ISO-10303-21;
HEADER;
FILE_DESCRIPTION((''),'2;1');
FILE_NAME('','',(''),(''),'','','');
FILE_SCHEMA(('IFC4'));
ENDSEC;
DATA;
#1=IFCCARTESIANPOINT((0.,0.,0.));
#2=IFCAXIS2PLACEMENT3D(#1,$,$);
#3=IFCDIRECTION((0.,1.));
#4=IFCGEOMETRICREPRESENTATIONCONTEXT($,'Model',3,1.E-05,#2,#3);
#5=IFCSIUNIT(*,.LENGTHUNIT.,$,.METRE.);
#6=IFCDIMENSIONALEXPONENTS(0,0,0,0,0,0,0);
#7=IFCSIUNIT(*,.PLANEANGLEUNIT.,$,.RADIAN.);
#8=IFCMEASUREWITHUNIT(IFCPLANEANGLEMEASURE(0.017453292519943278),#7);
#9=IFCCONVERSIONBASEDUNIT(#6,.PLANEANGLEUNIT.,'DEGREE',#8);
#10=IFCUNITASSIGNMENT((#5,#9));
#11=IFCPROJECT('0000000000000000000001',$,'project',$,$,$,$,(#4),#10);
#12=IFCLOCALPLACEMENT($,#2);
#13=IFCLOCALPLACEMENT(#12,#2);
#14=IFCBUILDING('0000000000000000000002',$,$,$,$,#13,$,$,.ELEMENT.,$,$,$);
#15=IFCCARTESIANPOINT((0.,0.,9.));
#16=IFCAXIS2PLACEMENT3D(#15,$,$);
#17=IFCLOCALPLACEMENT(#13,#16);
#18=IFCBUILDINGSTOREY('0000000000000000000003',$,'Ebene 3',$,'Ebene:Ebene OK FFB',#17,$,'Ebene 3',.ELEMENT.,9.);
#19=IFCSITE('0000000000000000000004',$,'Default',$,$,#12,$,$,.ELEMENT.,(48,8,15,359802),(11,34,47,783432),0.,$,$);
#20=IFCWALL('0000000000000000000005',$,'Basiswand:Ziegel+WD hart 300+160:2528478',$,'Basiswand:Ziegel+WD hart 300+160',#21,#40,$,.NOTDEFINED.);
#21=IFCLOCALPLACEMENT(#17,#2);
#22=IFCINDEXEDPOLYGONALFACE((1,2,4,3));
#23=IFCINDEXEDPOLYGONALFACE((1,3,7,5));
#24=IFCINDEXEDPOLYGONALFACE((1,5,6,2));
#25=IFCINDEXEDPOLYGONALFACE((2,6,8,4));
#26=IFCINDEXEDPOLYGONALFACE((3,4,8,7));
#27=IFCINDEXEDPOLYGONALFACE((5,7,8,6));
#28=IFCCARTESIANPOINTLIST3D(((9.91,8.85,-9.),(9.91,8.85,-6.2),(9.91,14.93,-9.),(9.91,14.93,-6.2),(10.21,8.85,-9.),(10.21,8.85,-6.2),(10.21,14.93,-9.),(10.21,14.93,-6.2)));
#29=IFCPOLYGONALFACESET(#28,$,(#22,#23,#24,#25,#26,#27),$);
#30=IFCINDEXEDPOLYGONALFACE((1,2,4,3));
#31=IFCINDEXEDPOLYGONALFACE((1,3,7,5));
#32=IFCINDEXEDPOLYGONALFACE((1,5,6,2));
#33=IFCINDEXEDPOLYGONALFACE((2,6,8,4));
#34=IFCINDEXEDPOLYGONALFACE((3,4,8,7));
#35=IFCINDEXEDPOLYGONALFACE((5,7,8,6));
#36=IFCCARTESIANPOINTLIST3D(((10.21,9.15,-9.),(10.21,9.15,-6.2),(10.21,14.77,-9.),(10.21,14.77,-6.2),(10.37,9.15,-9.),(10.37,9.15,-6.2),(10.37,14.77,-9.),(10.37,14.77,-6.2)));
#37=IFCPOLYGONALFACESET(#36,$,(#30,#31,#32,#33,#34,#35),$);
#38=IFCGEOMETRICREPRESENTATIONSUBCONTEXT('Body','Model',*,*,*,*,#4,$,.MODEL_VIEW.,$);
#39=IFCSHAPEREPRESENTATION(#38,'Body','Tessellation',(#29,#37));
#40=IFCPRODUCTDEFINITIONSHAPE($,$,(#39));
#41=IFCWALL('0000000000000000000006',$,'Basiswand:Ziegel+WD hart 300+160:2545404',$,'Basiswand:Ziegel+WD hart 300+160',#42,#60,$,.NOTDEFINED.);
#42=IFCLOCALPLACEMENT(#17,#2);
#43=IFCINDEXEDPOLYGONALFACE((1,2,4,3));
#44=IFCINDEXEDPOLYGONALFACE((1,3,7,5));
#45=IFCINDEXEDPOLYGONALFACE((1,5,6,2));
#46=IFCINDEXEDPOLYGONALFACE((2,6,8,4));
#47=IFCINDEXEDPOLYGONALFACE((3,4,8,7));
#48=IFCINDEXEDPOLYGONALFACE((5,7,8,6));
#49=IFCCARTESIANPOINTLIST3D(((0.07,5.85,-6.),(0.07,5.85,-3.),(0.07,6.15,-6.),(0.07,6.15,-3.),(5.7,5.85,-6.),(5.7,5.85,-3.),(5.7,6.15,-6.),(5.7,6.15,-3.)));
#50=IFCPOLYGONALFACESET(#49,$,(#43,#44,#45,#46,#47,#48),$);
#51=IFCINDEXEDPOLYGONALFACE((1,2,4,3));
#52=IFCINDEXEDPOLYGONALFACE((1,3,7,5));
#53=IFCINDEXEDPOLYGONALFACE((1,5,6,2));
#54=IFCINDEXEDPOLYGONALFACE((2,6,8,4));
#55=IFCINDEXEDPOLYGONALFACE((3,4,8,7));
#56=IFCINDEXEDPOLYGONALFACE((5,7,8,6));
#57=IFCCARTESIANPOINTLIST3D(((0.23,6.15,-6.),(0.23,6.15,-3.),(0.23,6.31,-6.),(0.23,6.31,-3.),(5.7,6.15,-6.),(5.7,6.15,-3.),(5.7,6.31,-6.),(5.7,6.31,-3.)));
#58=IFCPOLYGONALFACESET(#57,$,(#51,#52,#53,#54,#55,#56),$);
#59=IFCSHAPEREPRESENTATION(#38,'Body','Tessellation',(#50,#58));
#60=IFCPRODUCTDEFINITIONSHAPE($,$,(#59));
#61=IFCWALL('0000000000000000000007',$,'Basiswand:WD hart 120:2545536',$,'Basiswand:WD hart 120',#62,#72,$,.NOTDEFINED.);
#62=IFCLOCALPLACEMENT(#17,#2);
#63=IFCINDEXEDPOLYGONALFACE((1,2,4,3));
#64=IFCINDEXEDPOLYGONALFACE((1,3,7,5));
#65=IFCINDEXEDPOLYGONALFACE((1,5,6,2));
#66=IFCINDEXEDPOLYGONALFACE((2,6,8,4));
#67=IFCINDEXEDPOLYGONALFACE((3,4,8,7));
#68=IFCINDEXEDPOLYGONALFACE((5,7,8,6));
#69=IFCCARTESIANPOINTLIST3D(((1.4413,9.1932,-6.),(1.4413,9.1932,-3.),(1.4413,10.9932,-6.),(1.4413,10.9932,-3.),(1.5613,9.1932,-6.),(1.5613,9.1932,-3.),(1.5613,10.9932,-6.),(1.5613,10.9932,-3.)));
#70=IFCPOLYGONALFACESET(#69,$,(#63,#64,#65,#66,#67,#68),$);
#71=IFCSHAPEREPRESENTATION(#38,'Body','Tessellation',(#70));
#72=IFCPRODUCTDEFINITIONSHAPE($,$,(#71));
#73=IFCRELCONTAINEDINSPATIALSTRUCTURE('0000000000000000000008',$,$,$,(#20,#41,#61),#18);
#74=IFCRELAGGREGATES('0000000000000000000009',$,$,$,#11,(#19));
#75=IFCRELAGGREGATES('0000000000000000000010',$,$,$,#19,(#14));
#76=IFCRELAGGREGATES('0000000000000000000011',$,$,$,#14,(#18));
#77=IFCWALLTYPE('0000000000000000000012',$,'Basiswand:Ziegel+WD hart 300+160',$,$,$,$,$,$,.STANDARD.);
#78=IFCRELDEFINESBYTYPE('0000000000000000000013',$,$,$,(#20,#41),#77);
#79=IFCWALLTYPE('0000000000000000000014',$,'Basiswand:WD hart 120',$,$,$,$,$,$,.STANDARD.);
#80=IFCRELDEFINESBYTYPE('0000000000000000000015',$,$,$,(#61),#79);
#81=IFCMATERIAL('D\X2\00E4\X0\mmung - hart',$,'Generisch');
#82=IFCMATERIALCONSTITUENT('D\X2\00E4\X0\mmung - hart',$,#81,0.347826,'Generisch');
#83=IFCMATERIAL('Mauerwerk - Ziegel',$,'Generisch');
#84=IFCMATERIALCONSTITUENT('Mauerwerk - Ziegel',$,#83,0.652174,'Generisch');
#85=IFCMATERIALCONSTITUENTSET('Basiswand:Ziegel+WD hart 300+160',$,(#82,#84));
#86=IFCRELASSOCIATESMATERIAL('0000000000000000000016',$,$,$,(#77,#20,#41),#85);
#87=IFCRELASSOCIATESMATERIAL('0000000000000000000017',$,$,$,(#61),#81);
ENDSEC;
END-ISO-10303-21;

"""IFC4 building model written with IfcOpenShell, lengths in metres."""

from ifc_helpers import new_model, entity, si_unit, converted_unit, direction, frame, origin, place, context, subcontext, project, spatial, indexed_curve, outline, extrude, material, constituent, constituent_set, type_object, element, save


model = new_model("IFC4")

# Units and contexts
model_context = context("Model", 3, precision=1e-05, world=origin(), true_north=direction((0.0, 1.0)))
body_context = subcontext(model_context, "Body", "Model", "MODEL_VIEW")
ifc_project = project(units=[si_unit("LENGTHUNIT", "METRE"), converted_unit("PLANEANGLEUNIT", "DEGREE", entity("IfcPlaneAngleMeasure", 0.017453292519943278), si_unit("PLANEANGLEUNIT", "RADIAN"), dimensions=[0, 0, 0, 0, 0, 0, 0])], contexts=[model_context])

# Site, building, storey
site_placement = place(None, origin())
site = spatial("IfcSite", under=ifc_project, at=site_placement, Name="Default", CompositionType="ELEMENT", RefLatitude=(48, 8, 15, 359802), RefLongitude=(11, 34, 47, 783432), RefElevation=0.0)
building_placement = place(site_placement, origin())
building = spatial("IfcBuilding", under=site, at=building_placement, CompositionType="ELEMENT")
storey_placement = place(building_placement, frame((0.0, 0.0, 9.0)))
storey = spatial("IfcBuildingStorey", under=building, at=storey_placement, Name="Ebene 3", ObjectType="Ebene:Ebene OK FFB", LongName="Ebene 3", CompositionType="ELEMENT", Elevation=9.0)

# Shared definitions
ifc_material_1 = material(Name="Dämmung - hart", Category="Generisch")
ifc_constituent_1 = constituent(ifc_material_1, Name="Dämmung - hart", Category="Generisch", fraction=0.347826)
ifc_material_2 = material(Name="Mauerwerk - Ziegel", Category="Generisch")
ifc_constituent_2 = constituent(ifc_material_2, Name="Mauerwerk - Ziegel", Category="Generisch", fraction=0.652174)
ifc_constituent_set_1 = constituent_set(constituents=[ifc_constituent_1, ifc_constituent_2], Name="Basiswand:Ziegel+WD hart 300+160")
wall_type_1 = type_object("IfcWallType", Name="Basiswand:Ziegel+WD hart 300+160", PredefinedType="STANDARD", material=ifc_constituent_set_1)

# Wall
wall_1_placement = place(storey_placement, frame((10.14, 14.77, -9.0), z_axis=(0.0, 0.0, 1.0), x_axis=(0.0, -1.0, 0.0)))
element("IfcWall", 1, at=wall_1_placement, inside=storey, type_object=wall_type_1, material=ifc_constituent_set_1, Name="Basiswand:Ziegel+WD hart 300+160:2528478", ObjectType="Basiswand:Ziegel+WD hart 300+160", PredefinedType="NOTDEFINED", context=body_context, shape_type="SweptSolid", body=[
    extrude(outline(indexed_curve([(-1.4, -3.04), (1.4, -3.04), (1.4, 3.04), (-1.4, 3.04), (-1.4, -3.04)], self_intersect=False)), frame((2.88, -0.23, 1.4), z_axis=(0.0, 1.0, 0.0), x_axis=(0.0, 0.0, 1.0)), (0.0, 0.0, 1.0), 0.3),
    extrude(outline(indexed_curve([(-1.4, -2.81), (1.4, -2.81), (1.4, 2.81), (-1.4, 2.81), (-1.4, -2.81)], self_intersect=False)), frame((2.81, 0.07, 1.4), z_axis=(0.0, 1.0, 0.0), x_axis=(0.0, 0.0, 1.0)), (0.0, 0.0, 1.0), 0.16),
])

# Walls
wall_2_placement = place(storey_placement, frame((0.23, 6.08, -6.0)))
element("IfcWall", 2, at=wall_2_placement, inside=storey, type_object=wall_type_1, material=ifc_constituent_set_1, Name="Basiswand:Ziegel+WD hart 300+160:2545404", ObjectType="Basiswand:Ziegel+WD hart 300+160", PredefinedType="NOTDEFINED", context=body_context, shape_type="SweptSolid", body=[
    extrude(outline(indexed_curve([(-0.15, -2.815), (0.15, -2.815), (0.15, 2.815), (-0.15, 2.815), (-0.15, -2.815)], self_intersect=False)), frame((2.655, -0.08, 0.0), z_axis=(0.0, 0.0, 1.0), x_axis=(0.0, 1.0, 0.0)), (0.0, 0.0, 1.0), 3.0),
    extrude(outline(indexed_curve([(-0.08, -2.735), (0.08, -2.735), (0.08, 2.735), (-0.08, 2.735), (-0.08, -2.735)], self_intersect=False)), frame((2.735, 0.15, 0.0), z_axis=(0.0, 0.0, 1.0), x_axis=(0.0, 1.0, 0.0)), (0.0, 0.0, 1.0), 3.0),
])
wall_type_2 = type_object("IfcWallType", Name="Basiswand:WD hart 120", PredefinedType="STANDARD")
wall_3_placement = place(storey_placement, frame((1.5013, 10.9932, -6.0), z_axis=(0.0, 0.0, 1.0), x_axis=(0.0, -1.0, 0.0)))
element("IfcWall", 3, at=wall_3_placement, inside=storey, type_object=wall_type_2, material=ifc_material_1, Name="Basiswand:WD hart 120:2545536", ObjectType="Basiswand:WD hart 120", PredefinedType="NOTDEFINED", context=body_context, shape_type="SweptSolid", body=[
    extrude(outline(indexed_curve([(1.8, 0.06), (0.0, 0.06), (0.0, -0.06), (1.8, -0.06), (1.8, 0.06)], self_intersect=False)), origin(), (0.0, 0.0, 1.0), 3.0),
])

save(model, "model.ifc")
